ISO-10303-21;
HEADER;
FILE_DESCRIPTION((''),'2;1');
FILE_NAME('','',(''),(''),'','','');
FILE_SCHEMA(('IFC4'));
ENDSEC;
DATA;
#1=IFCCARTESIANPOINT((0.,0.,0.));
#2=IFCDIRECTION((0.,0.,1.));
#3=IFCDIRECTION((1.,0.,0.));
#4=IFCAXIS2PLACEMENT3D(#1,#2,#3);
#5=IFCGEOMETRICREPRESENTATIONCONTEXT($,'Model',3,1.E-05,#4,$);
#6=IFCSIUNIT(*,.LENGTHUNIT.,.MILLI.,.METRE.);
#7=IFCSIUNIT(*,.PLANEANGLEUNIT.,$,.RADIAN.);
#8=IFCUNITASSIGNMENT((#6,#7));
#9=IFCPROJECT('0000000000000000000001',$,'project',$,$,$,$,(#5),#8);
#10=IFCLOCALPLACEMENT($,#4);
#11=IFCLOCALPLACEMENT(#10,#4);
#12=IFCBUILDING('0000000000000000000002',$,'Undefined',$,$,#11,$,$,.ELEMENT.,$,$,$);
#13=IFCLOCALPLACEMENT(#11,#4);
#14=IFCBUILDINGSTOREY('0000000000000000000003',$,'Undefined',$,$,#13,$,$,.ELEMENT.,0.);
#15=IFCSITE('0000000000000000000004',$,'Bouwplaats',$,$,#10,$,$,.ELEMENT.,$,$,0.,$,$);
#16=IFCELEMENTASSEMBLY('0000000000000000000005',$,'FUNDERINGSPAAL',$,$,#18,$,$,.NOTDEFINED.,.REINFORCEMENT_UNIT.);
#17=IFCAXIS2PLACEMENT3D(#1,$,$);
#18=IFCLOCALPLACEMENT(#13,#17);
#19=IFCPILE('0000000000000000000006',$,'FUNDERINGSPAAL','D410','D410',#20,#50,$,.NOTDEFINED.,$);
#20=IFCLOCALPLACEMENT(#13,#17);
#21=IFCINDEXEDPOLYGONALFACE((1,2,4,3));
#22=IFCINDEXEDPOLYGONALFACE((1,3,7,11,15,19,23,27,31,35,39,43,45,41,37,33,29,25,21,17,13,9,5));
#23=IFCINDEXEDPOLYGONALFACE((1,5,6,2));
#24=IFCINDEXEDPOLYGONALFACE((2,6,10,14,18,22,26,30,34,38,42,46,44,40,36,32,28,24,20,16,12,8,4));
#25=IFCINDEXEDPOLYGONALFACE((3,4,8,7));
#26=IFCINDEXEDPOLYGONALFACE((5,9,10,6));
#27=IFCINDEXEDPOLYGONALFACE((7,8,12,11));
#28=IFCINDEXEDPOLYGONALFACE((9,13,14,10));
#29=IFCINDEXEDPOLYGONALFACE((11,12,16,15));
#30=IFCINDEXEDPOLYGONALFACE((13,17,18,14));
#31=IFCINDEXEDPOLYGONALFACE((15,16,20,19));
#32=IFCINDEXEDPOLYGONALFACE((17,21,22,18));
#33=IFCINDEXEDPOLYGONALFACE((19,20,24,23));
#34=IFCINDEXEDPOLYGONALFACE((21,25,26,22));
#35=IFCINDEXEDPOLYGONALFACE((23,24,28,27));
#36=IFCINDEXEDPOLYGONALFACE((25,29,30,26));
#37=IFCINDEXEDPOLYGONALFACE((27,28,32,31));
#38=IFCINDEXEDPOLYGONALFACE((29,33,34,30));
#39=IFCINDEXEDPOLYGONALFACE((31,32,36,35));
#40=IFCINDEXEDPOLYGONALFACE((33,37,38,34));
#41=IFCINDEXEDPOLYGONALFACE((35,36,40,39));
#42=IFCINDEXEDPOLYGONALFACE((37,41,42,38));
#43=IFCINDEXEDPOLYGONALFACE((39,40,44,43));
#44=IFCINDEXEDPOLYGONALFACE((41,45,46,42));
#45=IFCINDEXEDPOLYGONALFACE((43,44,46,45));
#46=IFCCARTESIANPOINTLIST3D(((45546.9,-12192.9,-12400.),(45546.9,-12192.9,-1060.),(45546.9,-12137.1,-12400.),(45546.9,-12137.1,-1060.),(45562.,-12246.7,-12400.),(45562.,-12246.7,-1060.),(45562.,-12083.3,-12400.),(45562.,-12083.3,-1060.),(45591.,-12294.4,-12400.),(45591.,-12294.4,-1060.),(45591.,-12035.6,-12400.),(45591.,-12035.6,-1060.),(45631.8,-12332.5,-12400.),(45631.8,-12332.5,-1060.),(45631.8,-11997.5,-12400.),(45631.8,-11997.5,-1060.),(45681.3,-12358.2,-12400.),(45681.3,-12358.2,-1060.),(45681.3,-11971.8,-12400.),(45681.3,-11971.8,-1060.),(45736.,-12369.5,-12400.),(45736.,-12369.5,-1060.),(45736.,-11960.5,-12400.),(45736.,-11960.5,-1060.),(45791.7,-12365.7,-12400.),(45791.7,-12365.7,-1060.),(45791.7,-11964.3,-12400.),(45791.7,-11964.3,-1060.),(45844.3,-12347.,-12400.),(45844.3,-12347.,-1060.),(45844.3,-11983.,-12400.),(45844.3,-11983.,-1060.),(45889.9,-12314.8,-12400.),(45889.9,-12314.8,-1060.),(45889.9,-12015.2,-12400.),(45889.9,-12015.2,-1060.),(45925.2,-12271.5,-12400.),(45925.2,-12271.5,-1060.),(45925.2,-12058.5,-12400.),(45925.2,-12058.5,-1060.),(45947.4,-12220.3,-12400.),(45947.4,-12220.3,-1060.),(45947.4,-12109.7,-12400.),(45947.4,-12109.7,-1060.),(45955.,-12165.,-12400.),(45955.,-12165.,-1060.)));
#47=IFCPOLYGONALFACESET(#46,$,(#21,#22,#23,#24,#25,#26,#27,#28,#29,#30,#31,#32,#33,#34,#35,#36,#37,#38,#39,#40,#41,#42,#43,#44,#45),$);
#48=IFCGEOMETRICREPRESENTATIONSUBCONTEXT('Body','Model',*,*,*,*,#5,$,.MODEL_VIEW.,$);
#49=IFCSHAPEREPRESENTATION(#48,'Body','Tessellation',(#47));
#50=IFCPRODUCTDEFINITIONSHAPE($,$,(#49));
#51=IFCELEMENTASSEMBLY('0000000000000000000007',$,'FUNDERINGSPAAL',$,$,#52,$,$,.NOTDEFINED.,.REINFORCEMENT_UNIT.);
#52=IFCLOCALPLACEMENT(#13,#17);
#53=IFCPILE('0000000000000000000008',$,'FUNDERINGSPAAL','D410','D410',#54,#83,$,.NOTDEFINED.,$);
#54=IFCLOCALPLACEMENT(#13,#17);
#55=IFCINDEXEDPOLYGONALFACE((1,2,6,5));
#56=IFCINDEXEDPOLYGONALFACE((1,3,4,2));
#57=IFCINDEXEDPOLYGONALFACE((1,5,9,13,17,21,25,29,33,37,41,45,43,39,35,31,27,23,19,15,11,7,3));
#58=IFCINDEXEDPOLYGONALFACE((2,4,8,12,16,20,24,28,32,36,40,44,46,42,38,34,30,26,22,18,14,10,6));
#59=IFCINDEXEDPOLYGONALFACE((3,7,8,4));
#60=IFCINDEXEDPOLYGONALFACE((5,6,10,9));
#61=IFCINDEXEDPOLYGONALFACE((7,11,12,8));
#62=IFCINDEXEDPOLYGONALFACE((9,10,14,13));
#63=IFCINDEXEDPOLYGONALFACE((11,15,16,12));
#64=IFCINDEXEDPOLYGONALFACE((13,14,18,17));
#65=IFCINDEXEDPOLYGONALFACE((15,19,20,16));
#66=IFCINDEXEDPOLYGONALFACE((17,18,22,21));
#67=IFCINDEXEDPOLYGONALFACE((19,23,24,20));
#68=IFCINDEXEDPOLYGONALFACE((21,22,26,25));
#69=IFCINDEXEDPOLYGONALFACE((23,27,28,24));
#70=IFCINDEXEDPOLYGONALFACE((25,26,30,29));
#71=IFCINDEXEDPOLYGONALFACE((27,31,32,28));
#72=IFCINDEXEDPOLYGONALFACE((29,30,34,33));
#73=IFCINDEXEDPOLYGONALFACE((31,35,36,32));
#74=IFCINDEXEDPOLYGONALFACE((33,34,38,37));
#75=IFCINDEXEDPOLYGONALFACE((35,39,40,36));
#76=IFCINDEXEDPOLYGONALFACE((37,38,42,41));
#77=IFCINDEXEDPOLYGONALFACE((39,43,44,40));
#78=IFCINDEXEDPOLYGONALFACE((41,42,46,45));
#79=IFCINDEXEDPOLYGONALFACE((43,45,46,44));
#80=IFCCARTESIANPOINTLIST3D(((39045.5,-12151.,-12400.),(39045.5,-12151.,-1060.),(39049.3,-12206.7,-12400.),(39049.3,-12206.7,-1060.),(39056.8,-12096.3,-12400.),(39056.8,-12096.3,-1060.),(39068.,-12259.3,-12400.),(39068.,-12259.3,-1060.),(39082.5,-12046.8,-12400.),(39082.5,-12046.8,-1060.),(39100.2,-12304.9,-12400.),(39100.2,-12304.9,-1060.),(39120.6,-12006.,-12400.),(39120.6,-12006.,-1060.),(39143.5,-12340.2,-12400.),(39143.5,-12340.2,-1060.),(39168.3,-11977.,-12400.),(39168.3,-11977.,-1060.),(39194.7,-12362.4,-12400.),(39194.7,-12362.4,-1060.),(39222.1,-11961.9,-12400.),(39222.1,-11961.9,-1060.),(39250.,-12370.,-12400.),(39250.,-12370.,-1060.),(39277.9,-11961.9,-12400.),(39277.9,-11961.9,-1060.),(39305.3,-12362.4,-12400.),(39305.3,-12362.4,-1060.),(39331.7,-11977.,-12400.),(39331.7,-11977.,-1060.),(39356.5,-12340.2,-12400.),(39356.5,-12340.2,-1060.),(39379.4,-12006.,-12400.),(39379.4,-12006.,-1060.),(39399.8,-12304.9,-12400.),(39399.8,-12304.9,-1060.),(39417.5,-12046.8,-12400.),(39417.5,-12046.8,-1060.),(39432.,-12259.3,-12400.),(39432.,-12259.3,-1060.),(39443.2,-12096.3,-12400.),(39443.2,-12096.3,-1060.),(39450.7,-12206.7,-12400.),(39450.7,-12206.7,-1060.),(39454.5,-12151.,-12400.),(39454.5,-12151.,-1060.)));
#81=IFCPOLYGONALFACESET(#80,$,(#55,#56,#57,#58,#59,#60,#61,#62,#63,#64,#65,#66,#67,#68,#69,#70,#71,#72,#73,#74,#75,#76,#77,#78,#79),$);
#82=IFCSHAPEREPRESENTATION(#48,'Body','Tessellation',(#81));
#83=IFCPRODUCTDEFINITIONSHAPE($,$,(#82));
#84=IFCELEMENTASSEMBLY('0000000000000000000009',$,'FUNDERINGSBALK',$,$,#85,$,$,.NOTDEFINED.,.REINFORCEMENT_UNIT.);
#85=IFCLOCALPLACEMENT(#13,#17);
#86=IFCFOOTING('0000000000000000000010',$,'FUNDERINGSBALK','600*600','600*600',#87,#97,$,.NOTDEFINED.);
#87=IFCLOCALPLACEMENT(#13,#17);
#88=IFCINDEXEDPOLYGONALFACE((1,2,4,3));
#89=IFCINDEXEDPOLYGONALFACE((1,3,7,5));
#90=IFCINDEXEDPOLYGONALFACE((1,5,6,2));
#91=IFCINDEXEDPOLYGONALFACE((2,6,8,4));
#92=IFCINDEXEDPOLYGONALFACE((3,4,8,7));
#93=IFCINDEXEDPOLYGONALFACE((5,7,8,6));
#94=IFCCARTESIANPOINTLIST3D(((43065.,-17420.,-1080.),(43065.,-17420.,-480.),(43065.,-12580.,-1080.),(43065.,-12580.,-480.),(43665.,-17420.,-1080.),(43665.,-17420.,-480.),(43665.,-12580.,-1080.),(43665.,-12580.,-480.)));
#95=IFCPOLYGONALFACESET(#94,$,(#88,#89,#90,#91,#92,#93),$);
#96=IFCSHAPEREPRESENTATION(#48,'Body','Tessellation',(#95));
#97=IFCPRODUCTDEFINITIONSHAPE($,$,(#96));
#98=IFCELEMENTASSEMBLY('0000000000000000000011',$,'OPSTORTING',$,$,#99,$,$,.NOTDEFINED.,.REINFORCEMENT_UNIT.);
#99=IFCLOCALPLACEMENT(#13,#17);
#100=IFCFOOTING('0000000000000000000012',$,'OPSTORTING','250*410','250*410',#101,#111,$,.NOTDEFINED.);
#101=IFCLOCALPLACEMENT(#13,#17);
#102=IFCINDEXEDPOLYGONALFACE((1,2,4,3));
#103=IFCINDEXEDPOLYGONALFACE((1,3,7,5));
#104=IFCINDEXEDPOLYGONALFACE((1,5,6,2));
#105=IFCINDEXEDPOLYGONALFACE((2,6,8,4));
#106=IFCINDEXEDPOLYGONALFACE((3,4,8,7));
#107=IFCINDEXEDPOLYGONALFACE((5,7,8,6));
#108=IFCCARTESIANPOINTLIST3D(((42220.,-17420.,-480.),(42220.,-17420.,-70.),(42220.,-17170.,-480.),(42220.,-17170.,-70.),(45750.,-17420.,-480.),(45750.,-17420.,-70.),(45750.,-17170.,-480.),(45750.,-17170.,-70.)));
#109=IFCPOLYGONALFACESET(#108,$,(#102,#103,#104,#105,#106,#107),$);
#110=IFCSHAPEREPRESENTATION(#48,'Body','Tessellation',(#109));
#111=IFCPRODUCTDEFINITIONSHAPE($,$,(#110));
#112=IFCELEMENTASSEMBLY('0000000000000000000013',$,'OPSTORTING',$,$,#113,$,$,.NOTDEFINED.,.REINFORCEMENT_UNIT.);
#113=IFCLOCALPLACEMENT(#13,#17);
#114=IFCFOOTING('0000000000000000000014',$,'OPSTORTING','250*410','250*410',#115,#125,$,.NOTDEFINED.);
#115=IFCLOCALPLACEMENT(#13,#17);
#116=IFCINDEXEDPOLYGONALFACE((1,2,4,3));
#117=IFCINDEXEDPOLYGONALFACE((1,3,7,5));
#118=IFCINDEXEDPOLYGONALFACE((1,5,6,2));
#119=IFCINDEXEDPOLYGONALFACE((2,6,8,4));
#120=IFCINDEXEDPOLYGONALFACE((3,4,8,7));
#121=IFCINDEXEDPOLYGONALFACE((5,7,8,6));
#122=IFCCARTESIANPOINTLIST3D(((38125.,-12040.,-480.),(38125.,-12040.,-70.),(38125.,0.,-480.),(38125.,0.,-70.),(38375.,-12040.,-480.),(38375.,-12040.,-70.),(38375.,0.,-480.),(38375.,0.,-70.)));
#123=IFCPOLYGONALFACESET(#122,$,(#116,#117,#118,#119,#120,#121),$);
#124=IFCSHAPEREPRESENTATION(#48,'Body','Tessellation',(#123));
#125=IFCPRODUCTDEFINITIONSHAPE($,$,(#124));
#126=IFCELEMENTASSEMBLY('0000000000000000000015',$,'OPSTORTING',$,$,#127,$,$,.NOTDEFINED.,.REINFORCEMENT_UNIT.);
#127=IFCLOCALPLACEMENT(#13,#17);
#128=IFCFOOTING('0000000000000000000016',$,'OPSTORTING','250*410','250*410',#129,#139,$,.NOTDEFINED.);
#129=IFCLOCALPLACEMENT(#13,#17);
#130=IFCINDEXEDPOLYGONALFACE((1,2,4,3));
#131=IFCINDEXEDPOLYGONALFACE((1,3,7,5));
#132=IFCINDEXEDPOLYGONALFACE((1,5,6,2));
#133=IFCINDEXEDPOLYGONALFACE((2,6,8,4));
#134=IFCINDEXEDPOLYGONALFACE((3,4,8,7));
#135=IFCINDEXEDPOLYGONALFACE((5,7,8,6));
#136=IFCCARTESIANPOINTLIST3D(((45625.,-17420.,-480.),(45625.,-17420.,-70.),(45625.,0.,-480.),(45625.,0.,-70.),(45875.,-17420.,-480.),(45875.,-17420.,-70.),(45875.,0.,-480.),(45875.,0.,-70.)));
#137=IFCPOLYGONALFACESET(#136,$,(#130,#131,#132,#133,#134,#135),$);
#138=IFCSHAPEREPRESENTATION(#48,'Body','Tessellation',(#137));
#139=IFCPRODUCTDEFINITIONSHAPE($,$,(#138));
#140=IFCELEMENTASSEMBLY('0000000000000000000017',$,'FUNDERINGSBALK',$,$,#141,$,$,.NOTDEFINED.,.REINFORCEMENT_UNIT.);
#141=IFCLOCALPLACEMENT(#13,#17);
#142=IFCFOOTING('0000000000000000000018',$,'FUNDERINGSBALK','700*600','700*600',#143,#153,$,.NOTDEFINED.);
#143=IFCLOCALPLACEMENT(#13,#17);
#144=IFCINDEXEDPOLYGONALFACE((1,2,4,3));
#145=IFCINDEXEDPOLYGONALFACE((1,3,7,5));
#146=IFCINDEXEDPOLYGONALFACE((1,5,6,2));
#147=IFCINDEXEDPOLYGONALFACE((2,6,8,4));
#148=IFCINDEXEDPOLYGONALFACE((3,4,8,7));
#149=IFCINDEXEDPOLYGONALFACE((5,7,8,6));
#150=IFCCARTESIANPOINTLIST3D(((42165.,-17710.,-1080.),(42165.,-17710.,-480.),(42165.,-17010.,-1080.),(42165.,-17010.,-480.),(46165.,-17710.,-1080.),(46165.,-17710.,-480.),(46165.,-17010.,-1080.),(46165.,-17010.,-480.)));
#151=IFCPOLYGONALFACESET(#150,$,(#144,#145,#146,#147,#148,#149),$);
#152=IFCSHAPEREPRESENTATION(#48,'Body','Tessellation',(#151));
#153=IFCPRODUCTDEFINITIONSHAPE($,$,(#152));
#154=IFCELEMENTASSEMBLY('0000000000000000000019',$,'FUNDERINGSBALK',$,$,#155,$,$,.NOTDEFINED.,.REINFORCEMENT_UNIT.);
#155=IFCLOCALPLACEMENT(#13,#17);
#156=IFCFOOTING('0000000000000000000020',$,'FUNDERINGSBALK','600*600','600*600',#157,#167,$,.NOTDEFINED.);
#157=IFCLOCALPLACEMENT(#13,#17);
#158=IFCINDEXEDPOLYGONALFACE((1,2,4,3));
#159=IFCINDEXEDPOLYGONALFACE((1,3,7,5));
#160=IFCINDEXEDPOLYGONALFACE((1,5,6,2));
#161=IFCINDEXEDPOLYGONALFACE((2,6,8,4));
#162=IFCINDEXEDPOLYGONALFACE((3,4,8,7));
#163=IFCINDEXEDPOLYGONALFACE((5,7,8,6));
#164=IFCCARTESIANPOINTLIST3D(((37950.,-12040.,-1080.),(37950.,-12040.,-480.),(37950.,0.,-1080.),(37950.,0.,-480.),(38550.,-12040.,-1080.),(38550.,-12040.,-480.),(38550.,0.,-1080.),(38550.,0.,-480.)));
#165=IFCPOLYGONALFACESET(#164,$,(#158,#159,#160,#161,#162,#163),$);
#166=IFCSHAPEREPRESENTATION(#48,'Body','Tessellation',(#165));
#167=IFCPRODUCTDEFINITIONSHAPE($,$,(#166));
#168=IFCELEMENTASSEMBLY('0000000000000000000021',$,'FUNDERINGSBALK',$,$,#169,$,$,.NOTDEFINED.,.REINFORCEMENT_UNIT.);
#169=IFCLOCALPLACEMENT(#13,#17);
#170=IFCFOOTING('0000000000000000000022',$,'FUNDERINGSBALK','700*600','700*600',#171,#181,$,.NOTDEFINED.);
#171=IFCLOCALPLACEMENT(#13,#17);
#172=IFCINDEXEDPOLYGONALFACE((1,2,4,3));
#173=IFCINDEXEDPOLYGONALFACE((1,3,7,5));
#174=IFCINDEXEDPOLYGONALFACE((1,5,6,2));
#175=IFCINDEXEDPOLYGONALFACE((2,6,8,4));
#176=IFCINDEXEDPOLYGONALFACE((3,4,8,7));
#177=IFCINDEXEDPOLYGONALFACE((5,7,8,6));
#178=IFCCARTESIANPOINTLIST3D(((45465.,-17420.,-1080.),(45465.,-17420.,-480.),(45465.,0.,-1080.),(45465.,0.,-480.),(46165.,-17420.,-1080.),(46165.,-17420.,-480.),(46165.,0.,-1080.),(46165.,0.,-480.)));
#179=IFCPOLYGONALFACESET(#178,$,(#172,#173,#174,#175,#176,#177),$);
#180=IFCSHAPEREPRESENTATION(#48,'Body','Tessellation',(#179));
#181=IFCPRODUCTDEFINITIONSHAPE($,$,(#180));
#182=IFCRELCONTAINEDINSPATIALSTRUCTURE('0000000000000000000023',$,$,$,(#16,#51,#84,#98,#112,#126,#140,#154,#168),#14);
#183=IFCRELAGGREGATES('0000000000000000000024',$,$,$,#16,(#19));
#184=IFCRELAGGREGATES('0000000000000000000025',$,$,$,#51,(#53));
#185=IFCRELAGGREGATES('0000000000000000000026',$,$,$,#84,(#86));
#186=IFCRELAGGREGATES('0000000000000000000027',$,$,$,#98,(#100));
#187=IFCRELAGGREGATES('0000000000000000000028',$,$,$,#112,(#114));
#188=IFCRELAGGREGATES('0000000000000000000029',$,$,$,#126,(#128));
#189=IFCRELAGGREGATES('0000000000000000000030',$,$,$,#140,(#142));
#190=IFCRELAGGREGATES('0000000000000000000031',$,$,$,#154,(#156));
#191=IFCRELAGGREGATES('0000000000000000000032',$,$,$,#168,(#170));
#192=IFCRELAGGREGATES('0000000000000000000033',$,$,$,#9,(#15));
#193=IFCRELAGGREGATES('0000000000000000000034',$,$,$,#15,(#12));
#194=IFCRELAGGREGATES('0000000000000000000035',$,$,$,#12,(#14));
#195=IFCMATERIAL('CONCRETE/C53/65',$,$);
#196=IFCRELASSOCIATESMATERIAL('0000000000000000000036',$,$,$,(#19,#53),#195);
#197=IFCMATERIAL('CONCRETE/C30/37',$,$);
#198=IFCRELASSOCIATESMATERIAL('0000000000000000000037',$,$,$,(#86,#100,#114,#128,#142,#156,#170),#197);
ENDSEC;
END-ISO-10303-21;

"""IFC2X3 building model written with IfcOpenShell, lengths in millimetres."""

from ifc_helpers import new_model, si_unit, frame, origin_with_axes, origin_2d_with_axis, place, context, subcontext, project, spatial, rectangle, circle, extrude, clip, halfspace, material, element, aggregate, save


model = new_model("IFC2X3")

# Units and contexts
model_context = context("Model", 3, precision=1e-05, world=origin_with_axes())
body_context = subcontext(model_context, "Body", "Model", "MODEL_VIEW")
ifc_project = project(units=[si_unit("LENGTHUNIT", "METRE", prefix="MILLI"), si_unit("PLANEANGLEUNIT", "RADIAN")], contexts=[model_context])

# Site, building, storey
site_placement = place(None, origin_with_axes())
site = spatial("IfcSite", under=ifc_project, at=site_placement, Name="Bouwplaats", CompositionType="ELEMENT", RefElevation=0.0)
building_placement = place(site_placement, origin_with_axes())
building = spatial("IfcBuilding", under=site, at=building_placement, Name="Undefined", CompositionType="ELEMENT")
storey_placement = place(building_placement, origin_with_axes())
storey = spatial("IfcBuildingStorey", under=building, at=storey_placement, Name="Undefined", CompositionType="ELEMENT", Elevation=0.0)

# Element assemblies, piles
ifc_material_1 = material(Name="CONCRETE/C53/65")
assembly_1_placement = place(storey_placement, origin_with_axes())
assembly_1 = element("IfcElementAssembly", 1, at=assembly_1_placement, inside=storey, Name="FUNDERINGSPAAL", AssemblyPlace="NOTDEFINED", PredefinedType="REINFORCEMENT_UNIT")
pile_1_placement = place(assembly_1_placement, frame((45750.0, -12165.0, -1060.0), z_axis=(0.0, 1.0, 0.0), x_axis=(0.0, 0.0, -1.0)))
pile_1 = element("IfcPile", 2, at=pile_1_placement, material=ifc_material_1, Name="FUNDERINGSPAAL", Description="D410", ObjectType="D410", PredefinedType="NOTDEFINED", context=body_context, shape_type="Clipping", body=[
    clip(extrude(circle(Radius=205.0, at=origin_2d_with_axis()), frame((11340.0, 0.0, 0.0), z_axis=(-1.0, 0.0, 0.0), x_axis=(0.0, -1.0, 0.0)), (0.0, 0.0, 1.0), 11340.0), halfspace(frame((0.0, 205.0, -205.0), z_axis=(-1.0, 0.0, 0.0), x_axis=(0.0, 0.0, 1.0)), False)),
])
aggregate(assembly_1, [pile_1])
assembly_2_placement = place(storey_placement, origin_with_axes())
assembly_2 = element("IfcElementAssembly", 3, at=assembly_2_placement, inside=storey, Name="FUNDERINGSPAAL", AssemblyPlace="NOTDEFINED", PredefinedType="REINFORCEMENT_UNIT")
pile_2_placement = place(assembly_2_placement, frame((39250.0, -12165.0, -1060.0), z_axis=(1.0, 0.0, 0.0), x_axis=(0.0, 0.0, -1.0)))
pile_2 = element("IfcPile", 4, at=pile_2_placement, material=ifc_material_1, Name="FUNDERINGSPAAL", Description="D410", ObjectType="D410", PredefinedType="NOTDEFINED", context=body_context, shape_type="Clipping", body=[
    clip(extrude(circle(Radius=205.0, at=origin_2d_with_axis()), frame((11340.0, 0.0, 0.0), z_axis=(-1.0, 0.0, 0.0), x_axis=(0.0, -1.0, 0.0)), (0.0, 0.0, 1.0), 11340.0), halfspace(frame((0.0, 205.0, -205.0), z_axis=(-1.0, 0.0, 0.0), x_axis=(0.0, 0.0, 1.0)), False)),
])
aggregate(assembly_2, [pile_2])

# Element assemblies, footings
assembly_3_placement = place(storey_placement, origin_with_axes())
assembly_3 = element("IfcElementAssembly", 5, at=assembly_3_placement, inside=storey, Name="FUNDERINGSBALK", AssemblyPlace="NOTDEFINED", PredefinedType="REINFORCEMENT_UNIT")
ifc_material_2 = material(Name="CONCRETE/C30/37")
footing_1_placement = place(assembly_3_placement, frame((43365.0, -17420.0, -780.0), z_axis=(0.0, 0.0, 1.0), x_axis=(0.0, 1.0, 0.0)))
footing_1 = element("IfcFooting", 6, at=footing_1_placement, material=ifc_material_2, Name="FUNDERINGSBALK", Description="600*600", ObjectType="600*600", PredefinedType="NOTDEFINED", context=body_context, shape_type="SweptSolid", body=[
    extrude(rectangle(XDim=600.0, YDim=600.0, at=origin_2d_with_axis()), frame((4840.0, 0.0, 0.0), z_axis=(-1.0, 0.0, 0.0), x_axis=(0.0, -1.0, 0.0)), (0.0, 0.0, 1.0), 4840.0),
])
aggregate(assembly_3, [footing_1])
assembly_4_placement = place(storey_placement, origin_with_axes())
assembly_4 = element("IfcElementAssembly", 7, at=assembly_4_placement, inside=storey, Name="OPSTORTING", AssemblyPlace="NOTDEFINED", PredefinedType="REINFORCEMENT_UNIT")
footing_2_placement = place(assembly_4_placement, frame((42220.0, -17295.0, -275.0), z_axis=(0.0, 0.0, 1.0), x_axis=(1.0, 0.0, 0.0)))
footing_2 = element("IfcFooting", 8, at=footing_2_placement, material=ifc_material_2, Name="OPSTORTING", Description="250*410", ObjectType="250*410", PredefinedType="NOTDEFINED", context=body_context, shape_type="SweptSolid", body=[
    extrude(rectangle(XDim=250.0, YDim=410.0, at=origin_2d_with_axis()), frame((3530.0, 0.0, 0.0), z_axis=(-1.0, 0.0, 0.0), x_axis=(0.0, -1.0, 0.0)), (0.0, 0.0, 1.0), 3530.0),
])
aggregate(assembly_4, [footing_2])
assembly_5_placement = place(storey_placement, origin_with_axes())
assembly_5 = element("IfcElementAssembly", 9, at=assembly_5_placement, inside=storey, Name="OPSTORTING", AssemblyPlace="NOTDEFINED", PredefinedType="REINFORCEMENT_UNIT")
footing_3_placement = place(assembly_5_placement, frame((38250.0, -12040.0, -275.0), z_axis=(0.0, 0.0, 1.0), x_axis=(0.0, 1.0, 0.0)))
footing_3 = element("IfcFooting", 10, at=footing_3_placement, material=ifc_material_2, Name="OPSTORTING", Description="250*410", ObjectType="250*410", PredefinedType="NOTDEFINED", context=body_context, shape_type="SweptSolid", body=[
    extrude(rectangle(XDim=250.0, YDim=410.0, at=origin_2d_with_axis()), frame((12040.0, 0.0, 0.0), z_axis=(-1.0, 0.0, 0.0), x_axis=(0.0, -1.0, 0.0)), (0.0, 0.0, 1.0), 12040.0),
])
aggregate(assembly_5, [footing_3])
assembly_6_placement = place(storey_placement, origin_with_axes())
assembly_6 = element("IfcElementAssembly", 11, at=assembly_6_placement, inside=storey, Name="OPSTORTING", AssemblyPlace="NOTDEFINED", PredefinedType="REINFORCEMENT_UNIT")
footing_4_placement = place(assembly_6_placement, frame((45750.0, -17420.0, -275.0), z_axis=(0.0, 0.0, 1.0), x_axis=(0.0, 1.0, 0.0)))
footing_4 = element("IfcFooting", 12, at=footing_4_placement, material=ifc_material_2, Name="OPSTORTING", Description="250*410", ObjectType="250*410", PredefinedType="NOTDEFINED", context=body_context, shape_type="SweptSolid", body=[
    extrude(rectangle(XDim=250.0, YDim=410.0, at=origin_2d_with_axis()), frame((17420.0, 0.0, 0.0), z_axis=(-1.0, 0.0, 0.0), x_axis=(0.0, -1.0, 0.0)), (0.0, 0.0, 1.0), 17420.0),
])
aggregate(assembly_6, [footing_4])
assembly_7_placement = place(storey_placement, origin_with_axes())
assembly_7 = element("IfcElementAssembly", 13, at=assembly_7_placement, inside=storey, Name="FUNDERINGSBALK", AssemblyPlace="NOTDEFINED", PredefinedType="REINFORCEMENT_UNIT")
footing_5_placement = place(assembly_7_placement, frame((42165.0, -17360.0, -780.0), z_axis=(0.0, 0.0, 1.0), x_axis=(1.0, 0.0, 0.0)))
footing_5 = element("IfcFooting", 14, at=footing_5_placement, material=ifc_material_2, Name="FUNDERINGSBALK", Description="700*600", ObjectType="700*600", PredefinedType="NOTDEFINED", context=body_context, shape_type="SweptSolid", body=[
    extrude(rectangle(XDim=700.0, YDim=600.0, at=origin_2d_with_axis()), frame((4000.0, 0.0, 0.0), z_axis=(-1.0, 0.0, 0.0), x_axis=(0.0, -1.0, 0.0)), (0.0, 0.0, 1.0), 4000.0),
])
aggregate(assembly_7, [footing_5])
assembly_8_placement = place(storey_placement, origin_with_axes())
assembly_8 = element("IfcElementAssembly", 15, at=assembly_8_placement, inside=storey, Name="FUNDERINGSBALK", AssemblyPlace="NOTDEFINED", PredefinedType="REINFORCEMENT_UNIT")
footing_6_placement = place(assembly_8_placement, frame((38250.0, -12040.0, -780.0), z_axis=(0.0, 0.0, 1.0), x_axis=(0.0, 1.0, 0.0)))
footing_6 = element("IfcFooting", 16, at=footing_6_placement, material=ifc_material_2, Name="FUNDERINGSBALK", Description="600*600", ObjectType="600*600", PredefinedType="NOTDEFINED", context=body_context, shape_type="SweptSolid", body=[
    extrude(rectangle(XDim=600.0, YDim=600.0, at=origin_2d_with_axis()), frame((12040.0, 0.0, 0.0), z_axis=(-1.0, 0.0, 0.0), x_axis=(0.0, -1.0, 0.0)), (0.0, 0.0, 1.0), 12040.0),
])
aggregate(assembly_8, [footing_6])
assembly_9_placement = place(storey_placement, origin_with_axes())
assembly_9 = element("IfcElementAssembly", 17, at=assembly_9_placement, inside=storey, Name="FUNDERINGSBALK", AssemblyPlace="NOTDEFINED", PredefinedType="REINFORCEMENT_UNIT")
footing_7_placement = place(assembly_9_placement, frame((45815.0, -17420.0, -780.0), z_axis=(0.0, 0.0, 1.0), x_axis=(0.0, 1.0, 0.0)))
footing_7 = element("IfcFooting", 18, at=footing_7_placement, material=ifc_material_2, Name="FUNDERINGSBALK", Description="700*600", ObjectType="700*600", PredefinedType="NOTDEFINED", context=body_context, shape_type="SweptSolid", body=[
    extrude(rectangle(XDim=700.0, YDim=600.0, at=origin_2d_with_axis()), frame((17420.0, 0.0, 0.0), z_axis=(-1.0, 0.0, 0.0), x_axis=(0.0, -1.0, 0.0)), (0.0, 0.0, 1.0), 17420.0),
])
aggregate(assembly_9, [footing_7])

save(model, "model.ifc")
